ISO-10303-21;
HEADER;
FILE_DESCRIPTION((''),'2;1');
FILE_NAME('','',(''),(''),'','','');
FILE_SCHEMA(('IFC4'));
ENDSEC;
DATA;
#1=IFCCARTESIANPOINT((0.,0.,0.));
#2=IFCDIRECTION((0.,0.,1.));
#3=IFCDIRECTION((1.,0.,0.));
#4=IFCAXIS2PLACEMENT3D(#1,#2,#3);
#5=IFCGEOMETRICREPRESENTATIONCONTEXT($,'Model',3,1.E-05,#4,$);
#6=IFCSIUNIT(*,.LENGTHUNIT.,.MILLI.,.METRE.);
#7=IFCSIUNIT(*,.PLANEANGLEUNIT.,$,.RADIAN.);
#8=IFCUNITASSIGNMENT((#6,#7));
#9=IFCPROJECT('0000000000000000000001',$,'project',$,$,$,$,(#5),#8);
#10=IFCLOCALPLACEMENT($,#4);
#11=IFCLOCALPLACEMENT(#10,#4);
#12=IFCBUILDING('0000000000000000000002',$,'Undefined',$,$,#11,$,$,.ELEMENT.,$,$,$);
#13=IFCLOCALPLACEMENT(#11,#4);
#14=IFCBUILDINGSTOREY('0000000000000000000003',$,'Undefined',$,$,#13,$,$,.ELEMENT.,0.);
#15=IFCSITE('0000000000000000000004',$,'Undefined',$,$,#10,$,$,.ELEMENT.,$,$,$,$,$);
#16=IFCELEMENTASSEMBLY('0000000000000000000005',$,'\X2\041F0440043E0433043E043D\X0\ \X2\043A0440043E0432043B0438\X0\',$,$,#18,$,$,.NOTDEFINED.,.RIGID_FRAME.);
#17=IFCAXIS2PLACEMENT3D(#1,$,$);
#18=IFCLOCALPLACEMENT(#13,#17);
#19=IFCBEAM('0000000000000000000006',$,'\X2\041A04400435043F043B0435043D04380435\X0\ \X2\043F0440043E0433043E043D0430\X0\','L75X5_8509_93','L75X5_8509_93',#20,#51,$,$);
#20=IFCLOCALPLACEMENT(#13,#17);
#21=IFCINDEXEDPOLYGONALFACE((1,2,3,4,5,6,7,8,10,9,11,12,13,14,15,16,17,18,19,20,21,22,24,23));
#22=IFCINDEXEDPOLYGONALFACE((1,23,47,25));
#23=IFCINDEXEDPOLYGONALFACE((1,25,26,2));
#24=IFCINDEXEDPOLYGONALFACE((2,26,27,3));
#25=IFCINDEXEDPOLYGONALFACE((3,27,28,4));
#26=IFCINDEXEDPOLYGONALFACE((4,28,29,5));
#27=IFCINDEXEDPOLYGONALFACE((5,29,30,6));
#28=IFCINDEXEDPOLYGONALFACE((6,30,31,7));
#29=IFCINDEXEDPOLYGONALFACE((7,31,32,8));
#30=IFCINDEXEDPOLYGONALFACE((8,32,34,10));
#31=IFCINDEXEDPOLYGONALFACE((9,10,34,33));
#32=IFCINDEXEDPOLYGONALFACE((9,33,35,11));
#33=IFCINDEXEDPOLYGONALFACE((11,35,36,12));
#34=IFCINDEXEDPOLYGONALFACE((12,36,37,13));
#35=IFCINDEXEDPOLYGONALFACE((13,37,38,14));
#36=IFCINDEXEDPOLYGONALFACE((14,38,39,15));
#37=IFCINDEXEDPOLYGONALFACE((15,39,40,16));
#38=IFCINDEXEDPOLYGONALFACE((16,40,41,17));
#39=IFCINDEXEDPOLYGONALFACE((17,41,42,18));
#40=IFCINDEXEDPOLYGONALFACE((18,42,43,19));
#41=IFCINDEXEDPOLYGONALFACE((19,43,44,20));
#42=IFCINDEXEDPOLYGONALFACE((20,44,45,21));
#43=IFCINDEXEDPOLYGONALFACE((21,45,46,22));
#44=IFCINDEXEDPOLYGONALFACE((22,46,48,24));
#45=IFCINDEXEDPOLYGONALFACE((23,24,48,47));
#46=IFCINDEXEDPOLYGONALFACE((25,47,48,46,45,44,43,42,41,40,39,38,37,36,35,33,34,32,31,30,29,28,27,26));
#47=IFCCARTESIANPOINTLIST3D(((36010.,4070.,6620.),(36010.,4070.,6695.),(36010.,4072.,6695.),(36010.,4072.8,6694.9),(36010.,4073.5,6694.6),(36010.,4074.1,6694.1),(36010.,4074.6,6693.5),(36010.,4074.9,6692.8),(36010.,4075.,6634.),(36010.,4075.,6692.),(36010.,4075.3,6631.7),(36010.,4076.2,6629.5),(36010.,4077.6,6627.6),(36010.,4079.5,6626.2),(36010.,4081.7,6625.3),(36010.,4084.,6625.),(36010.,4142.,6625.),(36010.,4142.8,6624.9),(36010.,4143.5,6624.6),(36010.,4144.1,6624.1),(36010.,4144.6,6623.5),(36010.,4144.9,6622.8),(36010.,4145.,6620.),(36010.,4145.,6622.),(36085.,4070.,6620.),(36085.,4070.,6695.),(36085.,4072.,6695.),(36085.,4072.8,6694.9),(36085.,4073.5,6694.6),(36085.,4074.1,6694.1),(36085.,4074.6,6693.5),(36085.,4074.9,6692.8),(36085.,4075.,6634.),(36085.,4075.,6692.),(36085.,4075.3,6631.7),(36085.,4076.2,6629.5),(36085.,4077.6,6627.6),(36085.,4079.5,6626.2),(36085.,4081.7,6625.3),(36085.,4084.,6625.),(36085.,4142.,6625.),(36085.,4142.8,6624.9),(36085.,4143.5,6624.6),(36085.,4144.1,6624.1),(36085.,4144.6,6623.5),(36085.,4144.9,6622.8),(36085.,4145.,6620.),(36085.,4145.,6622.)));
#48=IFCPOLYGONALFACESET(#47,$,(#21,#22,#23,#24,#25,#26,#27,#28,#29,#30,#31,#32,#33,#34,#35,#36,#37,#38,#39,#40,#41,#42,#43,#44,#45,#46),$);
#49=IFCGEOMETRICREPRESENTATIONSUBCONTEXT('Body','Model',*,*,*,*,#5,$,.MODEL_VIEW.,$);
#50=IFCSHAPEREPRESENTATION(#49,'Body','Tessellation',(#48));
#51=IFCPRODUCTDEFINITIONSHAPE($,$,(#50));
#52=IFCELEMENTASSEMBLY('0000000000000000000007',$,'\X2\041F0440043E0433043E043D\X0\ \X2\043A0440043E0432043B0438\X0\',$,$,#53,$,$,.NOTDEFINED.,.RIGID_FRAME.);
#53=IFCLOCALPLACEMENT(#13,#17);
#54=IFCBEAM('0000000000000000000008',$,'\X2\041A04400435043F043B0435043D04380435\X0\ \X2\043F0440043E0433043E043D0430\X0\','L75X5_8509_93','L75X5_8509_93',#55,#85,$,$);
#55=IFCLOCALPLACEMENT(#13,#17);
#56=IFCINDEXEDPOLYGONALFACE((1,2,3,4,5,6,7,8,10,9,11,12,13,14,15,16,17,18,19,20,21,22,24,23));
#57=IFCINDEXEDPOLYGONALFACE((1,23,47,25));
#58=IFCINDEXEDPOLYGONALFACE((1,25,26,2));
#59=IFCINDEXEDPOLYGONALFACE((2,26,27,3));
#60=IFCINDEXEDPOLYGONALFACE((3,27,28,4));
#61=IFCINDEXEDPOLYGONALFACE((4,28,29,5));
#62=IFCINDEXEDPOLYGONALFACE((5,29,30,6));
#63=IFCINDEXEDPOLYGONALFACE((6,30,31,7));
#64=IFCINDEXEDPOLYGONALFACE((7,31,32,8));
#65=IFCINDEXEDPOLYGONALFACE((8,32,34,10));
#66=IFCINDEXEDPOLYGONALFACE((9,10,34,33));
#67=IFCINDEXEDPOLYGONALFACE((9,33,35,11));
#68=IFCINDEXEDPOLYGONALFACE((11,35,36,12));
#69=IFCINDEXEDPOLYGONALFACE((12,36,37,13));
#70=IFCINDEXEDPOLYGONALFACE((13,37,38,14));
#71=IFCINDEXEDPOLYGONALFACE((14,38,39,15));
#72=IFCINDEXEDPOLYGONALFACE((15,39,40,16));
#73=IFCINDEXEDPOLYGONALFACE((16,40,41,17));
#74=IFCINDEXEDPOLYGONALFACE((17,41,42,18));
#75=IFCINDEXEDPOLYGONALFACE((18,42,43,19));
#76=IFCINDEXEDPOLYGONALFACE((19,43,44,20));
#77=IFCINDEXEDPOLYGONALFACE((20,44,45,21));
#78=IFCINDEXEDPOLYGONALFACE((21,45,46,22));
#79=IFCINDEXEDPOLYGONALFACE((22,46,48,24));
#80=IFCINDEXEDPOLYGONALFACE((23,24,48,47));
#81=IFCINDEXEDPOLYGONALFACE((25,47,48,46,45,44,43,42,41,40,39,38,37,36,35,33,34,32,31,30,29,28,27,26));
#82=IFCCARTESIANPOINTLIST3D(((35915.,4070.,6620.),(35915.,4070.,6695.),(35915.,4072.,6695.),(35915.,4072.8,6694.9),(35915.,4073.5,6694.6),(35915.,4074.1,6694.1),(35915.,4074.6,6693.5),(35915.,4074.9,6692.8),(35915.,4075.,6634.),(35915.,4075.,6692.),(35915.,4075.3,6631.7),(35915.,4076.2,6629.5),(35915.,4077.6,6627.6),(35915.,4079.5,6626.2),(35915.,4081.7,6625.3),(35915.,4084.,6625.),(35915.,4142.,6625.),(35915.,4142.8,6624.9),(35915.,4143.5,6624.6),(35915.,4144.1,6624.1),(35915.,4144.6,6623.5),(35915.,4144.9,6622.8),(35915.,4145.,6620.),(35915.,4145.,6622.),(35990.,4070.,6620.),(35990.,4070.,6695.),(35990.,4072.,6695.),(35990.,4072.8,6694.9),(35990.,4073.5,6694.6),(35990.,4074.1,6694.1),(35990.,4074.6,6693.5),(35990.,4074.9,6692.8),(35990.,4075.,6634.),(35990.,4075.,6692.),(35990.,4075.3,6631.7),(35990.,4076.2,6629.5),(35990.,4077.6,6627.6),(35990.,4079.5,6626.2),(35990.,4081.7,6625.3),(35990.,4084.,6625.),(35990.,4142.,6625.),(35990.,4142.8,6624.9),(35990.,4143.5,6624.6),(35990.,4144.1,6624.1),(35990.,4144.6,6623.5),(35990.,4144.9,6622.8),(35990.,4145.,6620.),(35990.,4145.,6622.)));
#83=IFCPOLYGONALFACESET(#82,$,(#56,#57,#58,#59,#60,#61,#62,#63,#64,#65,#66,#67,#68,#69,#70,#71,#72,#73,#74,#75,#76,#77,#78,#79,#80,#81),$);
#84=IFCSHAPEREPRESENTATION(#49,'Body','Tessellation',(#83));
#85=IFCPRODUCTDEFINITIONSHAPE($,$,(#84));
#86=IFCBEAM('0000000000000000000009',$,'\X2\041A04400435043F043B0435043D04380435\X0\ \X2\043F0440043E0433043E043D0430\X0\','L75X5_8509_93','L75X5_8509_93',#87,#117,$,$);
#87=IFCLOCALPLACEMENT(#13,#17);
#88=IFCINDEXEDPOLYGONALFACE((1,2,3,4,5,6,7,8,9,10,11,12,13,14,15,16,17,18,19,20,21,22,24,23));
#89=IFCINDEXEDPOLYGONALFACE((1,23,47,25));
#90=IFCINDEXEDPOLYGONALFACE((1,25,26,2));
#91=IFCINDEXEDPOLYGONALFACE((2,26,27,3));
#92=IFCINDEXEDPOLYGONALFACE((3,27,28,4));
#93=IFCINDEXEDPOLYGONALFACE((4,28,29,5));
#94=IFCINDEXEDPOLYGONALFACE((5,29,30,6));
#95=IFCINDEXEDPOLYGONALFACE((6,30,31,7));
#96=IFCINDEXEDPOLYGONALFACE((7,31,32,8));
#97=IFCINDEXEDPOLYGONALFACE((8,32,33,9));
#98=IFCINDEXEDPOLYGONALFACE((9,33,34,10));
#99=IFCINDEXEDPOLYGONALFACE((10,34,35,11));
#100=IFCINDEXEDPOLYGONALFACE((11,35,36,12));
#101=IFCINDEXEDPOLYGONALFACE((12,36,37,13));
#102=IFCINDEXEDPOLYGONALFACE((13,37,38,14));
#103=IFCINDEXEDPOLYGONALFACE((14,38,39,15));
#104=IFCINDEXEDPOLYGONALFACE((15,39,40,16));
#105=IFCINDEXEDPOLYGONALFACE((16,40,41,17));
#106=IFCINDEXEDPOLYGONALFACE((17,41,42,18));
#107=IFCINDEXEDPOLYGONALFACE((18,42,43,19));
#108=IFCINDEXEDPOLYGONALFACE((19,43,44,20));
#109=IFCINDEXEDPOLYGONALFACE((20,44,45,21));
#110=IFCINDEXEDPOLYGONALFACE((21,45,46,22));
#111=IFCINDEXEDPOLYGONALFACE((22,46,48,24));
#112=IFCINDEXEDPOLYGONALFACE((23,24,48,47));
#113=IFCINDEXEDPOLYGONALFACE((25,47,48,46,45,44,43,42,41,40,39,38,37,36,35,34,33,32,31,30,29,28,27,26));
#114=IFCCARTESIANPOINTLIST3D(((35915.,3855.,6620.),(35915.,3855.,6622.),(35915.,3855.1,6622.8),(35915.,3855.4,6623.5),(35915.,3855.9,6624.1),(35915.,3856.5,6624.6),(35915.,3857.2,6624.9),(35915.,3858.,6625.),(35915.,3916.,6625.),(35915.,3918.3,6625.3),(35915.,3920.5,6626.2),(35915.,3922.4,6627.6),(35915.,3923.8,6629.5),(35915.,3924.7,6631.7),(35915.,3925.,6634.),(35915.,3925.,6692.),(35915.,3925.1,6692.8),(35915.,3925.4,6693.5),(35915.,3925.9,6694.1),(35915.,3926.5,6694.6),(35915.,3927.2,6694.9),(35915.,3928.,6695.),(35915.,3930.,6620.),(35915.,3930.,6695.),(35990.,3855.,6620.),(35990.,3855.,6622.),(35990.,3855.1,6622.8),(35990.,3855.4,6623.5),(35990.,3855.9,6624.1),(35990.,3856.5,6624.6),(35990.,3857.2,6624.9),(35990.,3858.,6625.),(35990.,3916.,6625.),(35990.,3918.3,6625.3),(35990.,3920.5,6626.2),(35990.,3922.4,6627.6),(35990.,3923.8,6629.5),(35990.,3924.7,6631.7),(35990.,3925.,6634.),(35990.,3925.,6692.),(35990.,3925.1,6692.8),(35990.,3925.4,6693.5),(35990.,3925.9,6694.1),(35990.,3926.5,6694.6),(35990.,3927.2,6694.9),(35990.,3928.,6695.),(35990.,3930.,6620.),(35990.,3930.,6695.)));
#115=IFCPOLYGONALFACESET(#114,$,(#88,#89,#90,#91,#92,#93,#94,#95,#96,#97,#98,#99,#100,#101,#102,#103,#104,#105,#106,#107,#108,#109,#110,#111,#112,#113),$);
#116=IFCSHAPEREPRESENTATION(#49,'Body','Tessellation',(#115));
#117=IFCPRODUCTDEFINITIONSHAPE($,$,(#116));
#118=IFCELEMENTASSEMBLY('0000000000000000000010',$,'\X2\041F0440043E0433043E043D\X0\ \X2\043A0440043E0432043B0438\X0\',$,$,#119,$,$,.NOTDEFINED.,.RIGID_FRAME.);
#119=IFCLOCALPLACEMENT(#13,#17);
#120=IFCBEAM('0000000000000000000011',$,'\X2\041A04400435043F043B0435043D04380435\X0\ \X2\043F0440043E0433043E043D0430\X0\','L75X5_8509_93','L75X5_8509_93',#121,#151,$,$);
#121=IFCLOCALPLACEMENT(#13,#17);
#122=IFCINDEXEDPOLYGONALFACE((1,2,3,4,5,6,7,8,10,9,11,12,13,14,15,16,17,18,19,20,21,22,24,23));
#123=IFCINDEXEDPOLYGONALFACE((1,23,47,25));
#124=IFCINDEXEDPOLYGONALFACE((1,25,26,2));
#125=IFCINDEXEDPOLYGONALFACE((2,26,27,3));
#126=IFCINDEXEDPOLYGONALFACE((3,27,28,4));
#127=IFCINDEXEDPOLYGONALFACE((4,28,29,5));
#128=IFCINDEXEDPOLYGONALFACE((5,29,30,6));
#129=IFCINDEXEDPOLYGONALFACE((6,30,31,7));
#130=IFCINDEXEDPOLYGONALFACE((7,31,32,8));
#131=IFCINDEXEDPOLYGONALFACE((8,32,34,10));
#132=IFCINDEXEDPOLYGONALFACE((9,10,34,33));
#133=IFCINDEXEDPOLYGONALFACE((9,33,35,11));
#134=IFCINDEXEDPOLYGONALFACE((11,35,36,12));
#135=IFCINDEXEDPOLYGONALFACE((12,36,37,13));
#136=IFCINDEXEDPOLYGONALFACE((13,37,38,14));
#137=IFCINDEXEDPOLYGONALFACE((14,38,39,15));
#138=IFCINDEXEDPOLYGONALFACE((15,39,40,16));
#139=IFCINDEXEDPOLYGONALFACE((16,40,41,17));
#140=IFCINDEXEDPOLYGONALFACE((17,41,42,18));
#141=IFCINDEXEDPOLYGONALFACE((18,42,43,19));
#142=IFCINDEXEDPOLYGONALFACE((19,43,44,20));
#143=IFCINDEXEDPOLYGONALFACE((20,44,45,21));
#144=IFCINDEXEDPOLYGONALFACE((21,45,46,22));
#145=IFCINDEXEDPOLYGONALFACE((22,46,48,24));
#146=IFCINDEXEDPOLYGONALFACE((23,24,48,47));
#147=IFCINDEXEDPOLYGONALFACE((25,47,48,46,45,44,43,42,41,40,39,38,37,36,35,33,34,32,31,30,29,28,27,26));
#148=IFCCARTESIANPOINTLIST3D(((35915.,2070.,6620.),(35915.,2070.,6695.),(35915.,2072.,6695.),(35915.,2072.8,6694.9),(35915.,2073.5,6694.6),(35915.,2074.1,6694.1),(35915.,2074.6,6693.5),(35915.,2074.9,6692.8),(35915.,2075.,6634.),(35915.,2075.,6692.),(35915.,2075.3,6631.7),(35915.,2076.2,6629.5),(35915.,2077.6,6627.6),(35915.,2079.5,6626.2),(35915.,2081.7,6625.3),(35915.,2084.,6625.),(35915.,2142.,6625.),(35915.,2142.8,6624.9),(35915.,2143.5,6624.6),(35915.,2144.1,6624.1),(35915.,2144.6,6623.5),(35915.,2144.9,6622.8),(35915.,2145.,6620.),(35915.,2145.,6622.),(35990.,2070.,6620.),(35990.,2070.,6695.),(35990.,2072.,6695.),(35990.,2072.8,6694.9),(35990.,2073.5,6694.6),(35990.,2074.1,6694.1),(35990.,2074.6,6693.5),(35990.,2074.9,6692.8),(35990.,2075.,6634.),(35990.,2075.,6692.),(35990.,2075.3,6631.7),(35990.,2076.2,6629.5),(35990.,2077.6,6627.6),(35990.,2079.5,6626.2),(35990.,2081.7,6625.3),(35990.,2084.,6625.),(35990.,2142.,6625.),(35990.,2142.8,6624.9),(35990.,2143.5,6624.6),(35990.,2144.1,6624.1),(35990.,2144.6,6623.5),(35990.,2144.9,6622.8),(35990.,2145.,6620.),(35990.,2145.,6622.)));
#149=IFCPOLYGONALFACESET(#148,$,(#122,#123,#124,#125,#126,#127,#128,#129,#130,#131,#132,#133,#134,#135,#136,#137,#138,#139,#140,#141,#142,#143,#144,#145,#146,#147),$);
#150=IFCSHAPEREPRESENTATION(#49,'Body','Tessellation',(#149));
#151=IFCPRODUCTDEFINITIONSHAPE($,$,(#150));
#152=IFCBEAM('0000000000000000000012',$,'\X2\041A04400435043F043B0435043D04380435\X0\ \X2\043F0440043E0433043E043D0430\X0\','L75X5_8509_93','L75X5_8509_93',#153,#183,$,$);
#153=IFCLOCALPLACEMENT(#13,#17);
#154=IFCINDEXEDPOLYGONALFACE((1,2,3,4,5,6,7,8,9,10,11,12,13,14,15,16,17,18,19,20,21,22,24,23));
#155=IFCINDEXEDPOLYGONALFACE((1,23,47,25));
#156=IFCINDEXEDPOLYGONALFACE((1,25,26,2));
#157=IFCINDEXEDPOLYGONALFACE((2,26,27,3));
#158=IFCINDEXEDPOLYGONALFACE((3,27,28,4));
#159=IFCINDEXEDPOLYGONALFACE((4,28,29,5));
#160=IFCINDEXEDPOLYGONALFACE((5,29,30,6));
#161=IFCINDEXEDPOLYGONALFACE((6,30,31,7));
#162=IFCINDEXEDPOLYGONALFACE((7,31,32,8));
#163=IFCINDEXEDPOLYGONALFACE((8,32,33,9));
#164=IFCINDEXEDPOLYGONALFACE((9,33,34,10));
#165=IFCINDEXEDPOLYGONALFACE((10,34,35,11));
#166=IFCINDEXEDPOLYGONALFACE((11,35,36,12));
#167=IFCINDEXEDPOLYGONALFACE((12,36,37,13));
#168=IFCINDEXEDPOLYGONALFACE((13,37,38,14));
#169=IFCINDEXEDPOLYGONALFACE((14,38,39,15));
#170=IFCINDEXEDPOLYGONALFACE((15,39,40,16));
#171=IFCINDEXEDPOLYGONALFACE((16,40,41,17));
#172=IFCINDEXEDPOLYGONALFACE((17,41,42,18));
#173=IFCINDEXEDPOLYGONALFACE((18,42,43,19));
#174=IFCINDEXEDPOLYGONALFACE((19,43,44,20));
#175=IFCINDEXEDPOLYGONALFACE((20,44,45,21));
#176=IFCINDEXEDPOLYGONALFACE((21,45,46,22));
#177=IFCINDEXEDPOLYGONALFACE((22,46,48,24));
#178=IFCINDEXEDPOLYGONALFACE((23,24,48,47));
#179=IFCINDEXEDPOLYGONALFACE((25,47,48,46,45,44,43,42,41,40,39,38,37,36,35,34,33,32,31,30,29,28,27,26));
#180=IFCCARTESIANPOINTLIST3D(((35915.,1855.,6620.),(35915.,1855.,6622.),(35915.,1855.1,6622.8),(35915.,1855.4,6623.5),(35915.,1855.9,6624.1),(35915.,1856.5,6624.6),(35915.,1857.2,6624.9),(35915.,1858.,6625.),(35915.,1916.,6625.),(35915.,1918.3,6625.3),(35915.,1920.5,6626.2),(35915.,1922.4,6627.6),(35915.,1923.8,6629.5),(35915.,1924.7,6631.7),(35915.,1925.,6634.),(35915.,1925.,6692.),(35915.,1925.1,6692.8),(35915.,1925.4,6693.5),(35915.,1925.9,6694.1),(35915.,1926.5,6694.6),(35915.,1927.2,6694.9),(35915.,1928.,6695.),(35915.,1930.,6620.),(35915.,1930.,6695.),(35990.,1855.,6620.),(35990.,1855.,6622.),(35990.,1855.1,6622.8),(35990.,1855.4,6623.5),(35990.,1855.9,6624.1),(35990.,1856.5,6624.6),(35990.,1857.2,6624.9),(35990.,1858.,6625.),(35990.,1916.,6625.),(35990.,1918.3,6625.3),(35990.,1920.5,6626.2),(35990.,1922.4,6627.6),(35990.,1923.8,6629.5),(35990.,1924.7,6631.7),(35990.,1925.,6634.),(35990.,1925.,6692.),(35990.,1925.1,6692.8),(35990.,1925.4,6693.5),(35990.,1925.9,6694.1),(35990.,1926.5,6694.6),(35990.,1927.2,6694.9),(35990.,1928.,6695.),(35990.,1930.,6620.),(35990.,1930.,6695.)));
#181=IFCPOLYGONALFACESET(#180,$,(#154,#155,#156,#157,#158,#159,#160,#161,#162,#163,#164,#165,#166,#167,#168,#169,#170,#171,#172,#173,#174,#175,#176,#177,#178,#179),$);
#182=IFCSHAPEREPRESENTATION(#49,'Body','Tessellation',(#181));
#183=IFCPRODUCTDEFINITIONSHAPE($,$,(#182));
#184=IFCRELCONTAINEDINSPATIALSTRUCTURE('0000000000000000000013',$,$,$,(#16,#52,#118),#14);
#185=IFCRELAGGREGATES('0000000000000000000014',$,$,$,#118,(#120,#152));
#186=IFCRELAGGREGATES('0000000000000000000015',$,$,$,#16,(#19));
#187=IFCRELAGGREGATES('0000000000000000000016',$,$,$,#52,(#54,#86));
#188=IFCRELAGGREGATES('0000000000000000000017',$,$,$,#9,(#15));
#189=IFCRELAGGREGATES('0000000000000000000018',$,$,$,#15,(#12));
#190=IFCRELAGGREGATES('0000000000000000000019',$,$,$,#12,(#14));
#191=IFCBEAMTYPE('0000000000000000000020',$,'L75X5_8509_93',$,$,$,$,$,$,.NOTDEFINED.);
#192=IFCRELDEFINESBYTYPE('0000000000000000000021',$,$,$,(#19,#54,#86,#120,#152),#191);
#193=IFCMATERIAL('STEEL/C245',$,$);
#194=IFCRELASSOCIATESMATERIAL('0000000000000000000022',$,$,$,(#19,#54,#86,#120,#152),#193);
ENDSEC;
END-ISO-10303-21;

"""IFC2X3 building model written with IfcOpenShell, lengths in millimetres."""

from ifc_helpers import new_model, si_unit, frame, origin_with_axes, origin_2d_with_axis, place, context, subcontext, project, spatial, l_section, extrude, material, type_object, element, aggregate, save


model = new_model("IFC2X3")

# Units and contexts
model_context = context("Model", 3, precision=1e-05, world=origin_with_axes())
body_context = subcontext(model_context, "Body", "Model", "MODEL_VIEW")
ifc_project = project(units=[si_unit("LENGTHUNIT", "METRE", prefix="MILLI"), si_unit("PLANEANGLEUNIT", "RADIAN")], contexts=[model_context])

# Site, building, storey
site_placement = place(None, origin_with_axes())
site = spatial("IfcSite", under=ifc_project, at=site_placement, Name="Undefined", CompositionType="ELEMENT")
building_placement = place(site_placement, origin_with_axes())
building = spatial("IfcBuilding", under=site, at=building_placement, Name="Undefined", CompositionType="ELEMENT")
storey_placement = place(building_placement, origin_with_axes())
storey = spatial("IfcBuildingStorey", under=building, at=storey_placement, Name="Undefined", CompositionType="ELEMENT", Elevation=0.0)

# Shared definitions
ifc_material_1 = material(Name="STEEL/C245")
beam_type_1 = type_object("IfcBeamType", Name="L75X5_8509_93", PredefinedType="NOTDEFINED")

# Element assemblies, beams
assembly_1_placement = place(storey_placement, origin_with_axes())
assembly_1 = element("IfcElementAssembly", 1, at=assembly_1_placement, inside=storey, Name="Прогон кровли", AssemblyPlace="NOTDEFINED", PredefinedType="RIGID_FRAME")
beam_1_placement = place(assembly_1_placement, frame((36010.0, 4107.5, 6657.5), z_axis=(0.0, 1.0, 0.0), x_axis=(1.0, 0.0, 0.0)))
beam_1 = element("IfcBeam", 2, at=beam_1_placement, type_object=beam_type_1, material=ifc_material_1, Name="Крепление прогона", Description="L75X5_8509_93", ObjectType="L75X5_8509_93", context=body_context, shape_type="SweptSolid", body=[
    extrude(l_section(Depth=75.0, Width=75.0, Thickness=5.0, FilletRadius=9.0, EdgeRadius=3.0, at=origin_2d_with_axis()), frame((75.0, 0.0, 0.0), z_axis=(-1.0, 0.0, 0.0), x_axis=(0.0, -1.0, 0.0)), (0.0, 0.0, 1.0), 75.0),
])
assembly_2_placement = place(storey_placement, origin_with_axes())
assembly_2 = element("IfcElementAssembly", 3, at=assembly_2_placement, inside=storey, Name="Прогон кровли", AssemblyPlace="NOTDEFINED", PredefinedType="RIGID_FRAME")
beam_2_placement = place(assembly_2_placement, frame((35915.0, 4107.5, 6657.5), z_axis=(0.0, 1.0, 0.0), x_axis=(1.0, 0.0, 0.0)))
beam_2 = element("IfcBeam", 4, at=beam_2_placement, type_object=beam_type_1, material=ifc_material_1, Name="Крепление прогона", Description="L75X5_8509_93", ObjectType="L75X5_8509_93", context=body_context, shape_type="SweptSolid", body=[
    extrude(l_section(Depth=75.0, Width=75.0, Thickness=5.0, FilletRadius=9.0, EdgeRadius=3.0, at=origin_2d_with_axis()), frame((75.0, 0.0, 0.0), z_axis=(-1.0, 0.0, 0.0), x_axis=(0.0, -1.0, 0.0)), (0.0, 0.0, 1.0), 75.0),
])
beam_3_placement = place(assembly_2_placement, frame((35990.0, 3892.5, 6657.5), z_axis=(0.0, -1.0, 0.0), x_axis=(-1.0, 0.0, 0.0)))
beam_3 = element("IfcBeam", 5, at=beam_3_placement, type_object=beam_type_1, material=ifc_material_1, Name="Крепление прогона", Description="L75X5_8509_93", ObjectType="L75X5_8509_93", context=body_context, shape_type="SweptSolid", body=[
    extrude(l_section(Depth=75.0, Width=75.0, Thickness=5.0, FilletRadius=9.0, EdgeRadius=3.0, at=origin_2d_with_axis()), frame((75.0, 0.0, 0.0), z_axis=(-1.0, 0.0, 0.0), x_axis=(0.0, -1.0, 0.0)), (0.0, 0.0, 1.0), 75.0),
])
assembly_3_placement = place(storey_placement, origin_with_axes())
assembly_3 = element("IfcElementAssembly", 6, at=assembly_3_placement, inside=storey, Name="Прогон кровли", AssemblyPlace="NOTDEFINED", PredefinedType="RIGID_FRAME")
beam_4_placement = place(assembly_3_placement, frame((35915.0, 2107.5, 6657.5), z_axis=(0.0, 1.0, 0.0), x_axis=(1.0, 0.0, 0.0)))
beam_4 = element("IfcBeam", 7, at=beam_4_placement, type_object=beam_type_1, material=ifc_material_1, Name="Крепление прогона", Description="L75X5_8509_93", ObjectType="L75X5_8509_93", context=body_context, shape_type="SweptSolid", body=[
    extrude(l_section(Depth=75.0, Width=75.0, Thickness=5.0, FilletRadius=9.0, EdgeRadius=3.0, at=origin_2d_with_axis()), frame((75.0, 0.0, 0.0), z_axis=(-1.0, 0.0, 0.0), x_axis=(0.0, -1.0, 0.0)), (0.0, 0.0, 1.0), 75.0),
])
beam_5_placement = place(assembly_3_placement, frame((35990.0, 1892.5, 6657.5), z_axis=(0.0, -1.0, 0.0), x_axis=(-1.0, 0.0, 0.0)))
beam_5 = element("IfcBeam", 8, at=beam_5_placement, type_object=beam_type_1, material=ifc_material_1, Name="Крепление прогона", Description="L75X5_8509_93", ObjectType="L75X5_8509_93", context=body_context, shape_type="SweptSolid", body=[
    extrude(l_section(Depth=75.0, Width=75.0, Thickness=5.0, FilletRadius=9.0, EdgeRadius=3.0, at=origin_2d_with_axis()), frame((75.0, 0.0, 0.0), z_axis=(-1.0, 0.0, 0.0), x_axis=(0.0, -1.0, 0.0)), (0.0, 0.0, 1.0), 75.0),
])
aggregate(assembly_3, [beam_4, beam_5])

aggregate(assembly_1, [beam_1])
aggregate(assembly_2, [beam_2, beam_3])

save(model, "model.ifc")
